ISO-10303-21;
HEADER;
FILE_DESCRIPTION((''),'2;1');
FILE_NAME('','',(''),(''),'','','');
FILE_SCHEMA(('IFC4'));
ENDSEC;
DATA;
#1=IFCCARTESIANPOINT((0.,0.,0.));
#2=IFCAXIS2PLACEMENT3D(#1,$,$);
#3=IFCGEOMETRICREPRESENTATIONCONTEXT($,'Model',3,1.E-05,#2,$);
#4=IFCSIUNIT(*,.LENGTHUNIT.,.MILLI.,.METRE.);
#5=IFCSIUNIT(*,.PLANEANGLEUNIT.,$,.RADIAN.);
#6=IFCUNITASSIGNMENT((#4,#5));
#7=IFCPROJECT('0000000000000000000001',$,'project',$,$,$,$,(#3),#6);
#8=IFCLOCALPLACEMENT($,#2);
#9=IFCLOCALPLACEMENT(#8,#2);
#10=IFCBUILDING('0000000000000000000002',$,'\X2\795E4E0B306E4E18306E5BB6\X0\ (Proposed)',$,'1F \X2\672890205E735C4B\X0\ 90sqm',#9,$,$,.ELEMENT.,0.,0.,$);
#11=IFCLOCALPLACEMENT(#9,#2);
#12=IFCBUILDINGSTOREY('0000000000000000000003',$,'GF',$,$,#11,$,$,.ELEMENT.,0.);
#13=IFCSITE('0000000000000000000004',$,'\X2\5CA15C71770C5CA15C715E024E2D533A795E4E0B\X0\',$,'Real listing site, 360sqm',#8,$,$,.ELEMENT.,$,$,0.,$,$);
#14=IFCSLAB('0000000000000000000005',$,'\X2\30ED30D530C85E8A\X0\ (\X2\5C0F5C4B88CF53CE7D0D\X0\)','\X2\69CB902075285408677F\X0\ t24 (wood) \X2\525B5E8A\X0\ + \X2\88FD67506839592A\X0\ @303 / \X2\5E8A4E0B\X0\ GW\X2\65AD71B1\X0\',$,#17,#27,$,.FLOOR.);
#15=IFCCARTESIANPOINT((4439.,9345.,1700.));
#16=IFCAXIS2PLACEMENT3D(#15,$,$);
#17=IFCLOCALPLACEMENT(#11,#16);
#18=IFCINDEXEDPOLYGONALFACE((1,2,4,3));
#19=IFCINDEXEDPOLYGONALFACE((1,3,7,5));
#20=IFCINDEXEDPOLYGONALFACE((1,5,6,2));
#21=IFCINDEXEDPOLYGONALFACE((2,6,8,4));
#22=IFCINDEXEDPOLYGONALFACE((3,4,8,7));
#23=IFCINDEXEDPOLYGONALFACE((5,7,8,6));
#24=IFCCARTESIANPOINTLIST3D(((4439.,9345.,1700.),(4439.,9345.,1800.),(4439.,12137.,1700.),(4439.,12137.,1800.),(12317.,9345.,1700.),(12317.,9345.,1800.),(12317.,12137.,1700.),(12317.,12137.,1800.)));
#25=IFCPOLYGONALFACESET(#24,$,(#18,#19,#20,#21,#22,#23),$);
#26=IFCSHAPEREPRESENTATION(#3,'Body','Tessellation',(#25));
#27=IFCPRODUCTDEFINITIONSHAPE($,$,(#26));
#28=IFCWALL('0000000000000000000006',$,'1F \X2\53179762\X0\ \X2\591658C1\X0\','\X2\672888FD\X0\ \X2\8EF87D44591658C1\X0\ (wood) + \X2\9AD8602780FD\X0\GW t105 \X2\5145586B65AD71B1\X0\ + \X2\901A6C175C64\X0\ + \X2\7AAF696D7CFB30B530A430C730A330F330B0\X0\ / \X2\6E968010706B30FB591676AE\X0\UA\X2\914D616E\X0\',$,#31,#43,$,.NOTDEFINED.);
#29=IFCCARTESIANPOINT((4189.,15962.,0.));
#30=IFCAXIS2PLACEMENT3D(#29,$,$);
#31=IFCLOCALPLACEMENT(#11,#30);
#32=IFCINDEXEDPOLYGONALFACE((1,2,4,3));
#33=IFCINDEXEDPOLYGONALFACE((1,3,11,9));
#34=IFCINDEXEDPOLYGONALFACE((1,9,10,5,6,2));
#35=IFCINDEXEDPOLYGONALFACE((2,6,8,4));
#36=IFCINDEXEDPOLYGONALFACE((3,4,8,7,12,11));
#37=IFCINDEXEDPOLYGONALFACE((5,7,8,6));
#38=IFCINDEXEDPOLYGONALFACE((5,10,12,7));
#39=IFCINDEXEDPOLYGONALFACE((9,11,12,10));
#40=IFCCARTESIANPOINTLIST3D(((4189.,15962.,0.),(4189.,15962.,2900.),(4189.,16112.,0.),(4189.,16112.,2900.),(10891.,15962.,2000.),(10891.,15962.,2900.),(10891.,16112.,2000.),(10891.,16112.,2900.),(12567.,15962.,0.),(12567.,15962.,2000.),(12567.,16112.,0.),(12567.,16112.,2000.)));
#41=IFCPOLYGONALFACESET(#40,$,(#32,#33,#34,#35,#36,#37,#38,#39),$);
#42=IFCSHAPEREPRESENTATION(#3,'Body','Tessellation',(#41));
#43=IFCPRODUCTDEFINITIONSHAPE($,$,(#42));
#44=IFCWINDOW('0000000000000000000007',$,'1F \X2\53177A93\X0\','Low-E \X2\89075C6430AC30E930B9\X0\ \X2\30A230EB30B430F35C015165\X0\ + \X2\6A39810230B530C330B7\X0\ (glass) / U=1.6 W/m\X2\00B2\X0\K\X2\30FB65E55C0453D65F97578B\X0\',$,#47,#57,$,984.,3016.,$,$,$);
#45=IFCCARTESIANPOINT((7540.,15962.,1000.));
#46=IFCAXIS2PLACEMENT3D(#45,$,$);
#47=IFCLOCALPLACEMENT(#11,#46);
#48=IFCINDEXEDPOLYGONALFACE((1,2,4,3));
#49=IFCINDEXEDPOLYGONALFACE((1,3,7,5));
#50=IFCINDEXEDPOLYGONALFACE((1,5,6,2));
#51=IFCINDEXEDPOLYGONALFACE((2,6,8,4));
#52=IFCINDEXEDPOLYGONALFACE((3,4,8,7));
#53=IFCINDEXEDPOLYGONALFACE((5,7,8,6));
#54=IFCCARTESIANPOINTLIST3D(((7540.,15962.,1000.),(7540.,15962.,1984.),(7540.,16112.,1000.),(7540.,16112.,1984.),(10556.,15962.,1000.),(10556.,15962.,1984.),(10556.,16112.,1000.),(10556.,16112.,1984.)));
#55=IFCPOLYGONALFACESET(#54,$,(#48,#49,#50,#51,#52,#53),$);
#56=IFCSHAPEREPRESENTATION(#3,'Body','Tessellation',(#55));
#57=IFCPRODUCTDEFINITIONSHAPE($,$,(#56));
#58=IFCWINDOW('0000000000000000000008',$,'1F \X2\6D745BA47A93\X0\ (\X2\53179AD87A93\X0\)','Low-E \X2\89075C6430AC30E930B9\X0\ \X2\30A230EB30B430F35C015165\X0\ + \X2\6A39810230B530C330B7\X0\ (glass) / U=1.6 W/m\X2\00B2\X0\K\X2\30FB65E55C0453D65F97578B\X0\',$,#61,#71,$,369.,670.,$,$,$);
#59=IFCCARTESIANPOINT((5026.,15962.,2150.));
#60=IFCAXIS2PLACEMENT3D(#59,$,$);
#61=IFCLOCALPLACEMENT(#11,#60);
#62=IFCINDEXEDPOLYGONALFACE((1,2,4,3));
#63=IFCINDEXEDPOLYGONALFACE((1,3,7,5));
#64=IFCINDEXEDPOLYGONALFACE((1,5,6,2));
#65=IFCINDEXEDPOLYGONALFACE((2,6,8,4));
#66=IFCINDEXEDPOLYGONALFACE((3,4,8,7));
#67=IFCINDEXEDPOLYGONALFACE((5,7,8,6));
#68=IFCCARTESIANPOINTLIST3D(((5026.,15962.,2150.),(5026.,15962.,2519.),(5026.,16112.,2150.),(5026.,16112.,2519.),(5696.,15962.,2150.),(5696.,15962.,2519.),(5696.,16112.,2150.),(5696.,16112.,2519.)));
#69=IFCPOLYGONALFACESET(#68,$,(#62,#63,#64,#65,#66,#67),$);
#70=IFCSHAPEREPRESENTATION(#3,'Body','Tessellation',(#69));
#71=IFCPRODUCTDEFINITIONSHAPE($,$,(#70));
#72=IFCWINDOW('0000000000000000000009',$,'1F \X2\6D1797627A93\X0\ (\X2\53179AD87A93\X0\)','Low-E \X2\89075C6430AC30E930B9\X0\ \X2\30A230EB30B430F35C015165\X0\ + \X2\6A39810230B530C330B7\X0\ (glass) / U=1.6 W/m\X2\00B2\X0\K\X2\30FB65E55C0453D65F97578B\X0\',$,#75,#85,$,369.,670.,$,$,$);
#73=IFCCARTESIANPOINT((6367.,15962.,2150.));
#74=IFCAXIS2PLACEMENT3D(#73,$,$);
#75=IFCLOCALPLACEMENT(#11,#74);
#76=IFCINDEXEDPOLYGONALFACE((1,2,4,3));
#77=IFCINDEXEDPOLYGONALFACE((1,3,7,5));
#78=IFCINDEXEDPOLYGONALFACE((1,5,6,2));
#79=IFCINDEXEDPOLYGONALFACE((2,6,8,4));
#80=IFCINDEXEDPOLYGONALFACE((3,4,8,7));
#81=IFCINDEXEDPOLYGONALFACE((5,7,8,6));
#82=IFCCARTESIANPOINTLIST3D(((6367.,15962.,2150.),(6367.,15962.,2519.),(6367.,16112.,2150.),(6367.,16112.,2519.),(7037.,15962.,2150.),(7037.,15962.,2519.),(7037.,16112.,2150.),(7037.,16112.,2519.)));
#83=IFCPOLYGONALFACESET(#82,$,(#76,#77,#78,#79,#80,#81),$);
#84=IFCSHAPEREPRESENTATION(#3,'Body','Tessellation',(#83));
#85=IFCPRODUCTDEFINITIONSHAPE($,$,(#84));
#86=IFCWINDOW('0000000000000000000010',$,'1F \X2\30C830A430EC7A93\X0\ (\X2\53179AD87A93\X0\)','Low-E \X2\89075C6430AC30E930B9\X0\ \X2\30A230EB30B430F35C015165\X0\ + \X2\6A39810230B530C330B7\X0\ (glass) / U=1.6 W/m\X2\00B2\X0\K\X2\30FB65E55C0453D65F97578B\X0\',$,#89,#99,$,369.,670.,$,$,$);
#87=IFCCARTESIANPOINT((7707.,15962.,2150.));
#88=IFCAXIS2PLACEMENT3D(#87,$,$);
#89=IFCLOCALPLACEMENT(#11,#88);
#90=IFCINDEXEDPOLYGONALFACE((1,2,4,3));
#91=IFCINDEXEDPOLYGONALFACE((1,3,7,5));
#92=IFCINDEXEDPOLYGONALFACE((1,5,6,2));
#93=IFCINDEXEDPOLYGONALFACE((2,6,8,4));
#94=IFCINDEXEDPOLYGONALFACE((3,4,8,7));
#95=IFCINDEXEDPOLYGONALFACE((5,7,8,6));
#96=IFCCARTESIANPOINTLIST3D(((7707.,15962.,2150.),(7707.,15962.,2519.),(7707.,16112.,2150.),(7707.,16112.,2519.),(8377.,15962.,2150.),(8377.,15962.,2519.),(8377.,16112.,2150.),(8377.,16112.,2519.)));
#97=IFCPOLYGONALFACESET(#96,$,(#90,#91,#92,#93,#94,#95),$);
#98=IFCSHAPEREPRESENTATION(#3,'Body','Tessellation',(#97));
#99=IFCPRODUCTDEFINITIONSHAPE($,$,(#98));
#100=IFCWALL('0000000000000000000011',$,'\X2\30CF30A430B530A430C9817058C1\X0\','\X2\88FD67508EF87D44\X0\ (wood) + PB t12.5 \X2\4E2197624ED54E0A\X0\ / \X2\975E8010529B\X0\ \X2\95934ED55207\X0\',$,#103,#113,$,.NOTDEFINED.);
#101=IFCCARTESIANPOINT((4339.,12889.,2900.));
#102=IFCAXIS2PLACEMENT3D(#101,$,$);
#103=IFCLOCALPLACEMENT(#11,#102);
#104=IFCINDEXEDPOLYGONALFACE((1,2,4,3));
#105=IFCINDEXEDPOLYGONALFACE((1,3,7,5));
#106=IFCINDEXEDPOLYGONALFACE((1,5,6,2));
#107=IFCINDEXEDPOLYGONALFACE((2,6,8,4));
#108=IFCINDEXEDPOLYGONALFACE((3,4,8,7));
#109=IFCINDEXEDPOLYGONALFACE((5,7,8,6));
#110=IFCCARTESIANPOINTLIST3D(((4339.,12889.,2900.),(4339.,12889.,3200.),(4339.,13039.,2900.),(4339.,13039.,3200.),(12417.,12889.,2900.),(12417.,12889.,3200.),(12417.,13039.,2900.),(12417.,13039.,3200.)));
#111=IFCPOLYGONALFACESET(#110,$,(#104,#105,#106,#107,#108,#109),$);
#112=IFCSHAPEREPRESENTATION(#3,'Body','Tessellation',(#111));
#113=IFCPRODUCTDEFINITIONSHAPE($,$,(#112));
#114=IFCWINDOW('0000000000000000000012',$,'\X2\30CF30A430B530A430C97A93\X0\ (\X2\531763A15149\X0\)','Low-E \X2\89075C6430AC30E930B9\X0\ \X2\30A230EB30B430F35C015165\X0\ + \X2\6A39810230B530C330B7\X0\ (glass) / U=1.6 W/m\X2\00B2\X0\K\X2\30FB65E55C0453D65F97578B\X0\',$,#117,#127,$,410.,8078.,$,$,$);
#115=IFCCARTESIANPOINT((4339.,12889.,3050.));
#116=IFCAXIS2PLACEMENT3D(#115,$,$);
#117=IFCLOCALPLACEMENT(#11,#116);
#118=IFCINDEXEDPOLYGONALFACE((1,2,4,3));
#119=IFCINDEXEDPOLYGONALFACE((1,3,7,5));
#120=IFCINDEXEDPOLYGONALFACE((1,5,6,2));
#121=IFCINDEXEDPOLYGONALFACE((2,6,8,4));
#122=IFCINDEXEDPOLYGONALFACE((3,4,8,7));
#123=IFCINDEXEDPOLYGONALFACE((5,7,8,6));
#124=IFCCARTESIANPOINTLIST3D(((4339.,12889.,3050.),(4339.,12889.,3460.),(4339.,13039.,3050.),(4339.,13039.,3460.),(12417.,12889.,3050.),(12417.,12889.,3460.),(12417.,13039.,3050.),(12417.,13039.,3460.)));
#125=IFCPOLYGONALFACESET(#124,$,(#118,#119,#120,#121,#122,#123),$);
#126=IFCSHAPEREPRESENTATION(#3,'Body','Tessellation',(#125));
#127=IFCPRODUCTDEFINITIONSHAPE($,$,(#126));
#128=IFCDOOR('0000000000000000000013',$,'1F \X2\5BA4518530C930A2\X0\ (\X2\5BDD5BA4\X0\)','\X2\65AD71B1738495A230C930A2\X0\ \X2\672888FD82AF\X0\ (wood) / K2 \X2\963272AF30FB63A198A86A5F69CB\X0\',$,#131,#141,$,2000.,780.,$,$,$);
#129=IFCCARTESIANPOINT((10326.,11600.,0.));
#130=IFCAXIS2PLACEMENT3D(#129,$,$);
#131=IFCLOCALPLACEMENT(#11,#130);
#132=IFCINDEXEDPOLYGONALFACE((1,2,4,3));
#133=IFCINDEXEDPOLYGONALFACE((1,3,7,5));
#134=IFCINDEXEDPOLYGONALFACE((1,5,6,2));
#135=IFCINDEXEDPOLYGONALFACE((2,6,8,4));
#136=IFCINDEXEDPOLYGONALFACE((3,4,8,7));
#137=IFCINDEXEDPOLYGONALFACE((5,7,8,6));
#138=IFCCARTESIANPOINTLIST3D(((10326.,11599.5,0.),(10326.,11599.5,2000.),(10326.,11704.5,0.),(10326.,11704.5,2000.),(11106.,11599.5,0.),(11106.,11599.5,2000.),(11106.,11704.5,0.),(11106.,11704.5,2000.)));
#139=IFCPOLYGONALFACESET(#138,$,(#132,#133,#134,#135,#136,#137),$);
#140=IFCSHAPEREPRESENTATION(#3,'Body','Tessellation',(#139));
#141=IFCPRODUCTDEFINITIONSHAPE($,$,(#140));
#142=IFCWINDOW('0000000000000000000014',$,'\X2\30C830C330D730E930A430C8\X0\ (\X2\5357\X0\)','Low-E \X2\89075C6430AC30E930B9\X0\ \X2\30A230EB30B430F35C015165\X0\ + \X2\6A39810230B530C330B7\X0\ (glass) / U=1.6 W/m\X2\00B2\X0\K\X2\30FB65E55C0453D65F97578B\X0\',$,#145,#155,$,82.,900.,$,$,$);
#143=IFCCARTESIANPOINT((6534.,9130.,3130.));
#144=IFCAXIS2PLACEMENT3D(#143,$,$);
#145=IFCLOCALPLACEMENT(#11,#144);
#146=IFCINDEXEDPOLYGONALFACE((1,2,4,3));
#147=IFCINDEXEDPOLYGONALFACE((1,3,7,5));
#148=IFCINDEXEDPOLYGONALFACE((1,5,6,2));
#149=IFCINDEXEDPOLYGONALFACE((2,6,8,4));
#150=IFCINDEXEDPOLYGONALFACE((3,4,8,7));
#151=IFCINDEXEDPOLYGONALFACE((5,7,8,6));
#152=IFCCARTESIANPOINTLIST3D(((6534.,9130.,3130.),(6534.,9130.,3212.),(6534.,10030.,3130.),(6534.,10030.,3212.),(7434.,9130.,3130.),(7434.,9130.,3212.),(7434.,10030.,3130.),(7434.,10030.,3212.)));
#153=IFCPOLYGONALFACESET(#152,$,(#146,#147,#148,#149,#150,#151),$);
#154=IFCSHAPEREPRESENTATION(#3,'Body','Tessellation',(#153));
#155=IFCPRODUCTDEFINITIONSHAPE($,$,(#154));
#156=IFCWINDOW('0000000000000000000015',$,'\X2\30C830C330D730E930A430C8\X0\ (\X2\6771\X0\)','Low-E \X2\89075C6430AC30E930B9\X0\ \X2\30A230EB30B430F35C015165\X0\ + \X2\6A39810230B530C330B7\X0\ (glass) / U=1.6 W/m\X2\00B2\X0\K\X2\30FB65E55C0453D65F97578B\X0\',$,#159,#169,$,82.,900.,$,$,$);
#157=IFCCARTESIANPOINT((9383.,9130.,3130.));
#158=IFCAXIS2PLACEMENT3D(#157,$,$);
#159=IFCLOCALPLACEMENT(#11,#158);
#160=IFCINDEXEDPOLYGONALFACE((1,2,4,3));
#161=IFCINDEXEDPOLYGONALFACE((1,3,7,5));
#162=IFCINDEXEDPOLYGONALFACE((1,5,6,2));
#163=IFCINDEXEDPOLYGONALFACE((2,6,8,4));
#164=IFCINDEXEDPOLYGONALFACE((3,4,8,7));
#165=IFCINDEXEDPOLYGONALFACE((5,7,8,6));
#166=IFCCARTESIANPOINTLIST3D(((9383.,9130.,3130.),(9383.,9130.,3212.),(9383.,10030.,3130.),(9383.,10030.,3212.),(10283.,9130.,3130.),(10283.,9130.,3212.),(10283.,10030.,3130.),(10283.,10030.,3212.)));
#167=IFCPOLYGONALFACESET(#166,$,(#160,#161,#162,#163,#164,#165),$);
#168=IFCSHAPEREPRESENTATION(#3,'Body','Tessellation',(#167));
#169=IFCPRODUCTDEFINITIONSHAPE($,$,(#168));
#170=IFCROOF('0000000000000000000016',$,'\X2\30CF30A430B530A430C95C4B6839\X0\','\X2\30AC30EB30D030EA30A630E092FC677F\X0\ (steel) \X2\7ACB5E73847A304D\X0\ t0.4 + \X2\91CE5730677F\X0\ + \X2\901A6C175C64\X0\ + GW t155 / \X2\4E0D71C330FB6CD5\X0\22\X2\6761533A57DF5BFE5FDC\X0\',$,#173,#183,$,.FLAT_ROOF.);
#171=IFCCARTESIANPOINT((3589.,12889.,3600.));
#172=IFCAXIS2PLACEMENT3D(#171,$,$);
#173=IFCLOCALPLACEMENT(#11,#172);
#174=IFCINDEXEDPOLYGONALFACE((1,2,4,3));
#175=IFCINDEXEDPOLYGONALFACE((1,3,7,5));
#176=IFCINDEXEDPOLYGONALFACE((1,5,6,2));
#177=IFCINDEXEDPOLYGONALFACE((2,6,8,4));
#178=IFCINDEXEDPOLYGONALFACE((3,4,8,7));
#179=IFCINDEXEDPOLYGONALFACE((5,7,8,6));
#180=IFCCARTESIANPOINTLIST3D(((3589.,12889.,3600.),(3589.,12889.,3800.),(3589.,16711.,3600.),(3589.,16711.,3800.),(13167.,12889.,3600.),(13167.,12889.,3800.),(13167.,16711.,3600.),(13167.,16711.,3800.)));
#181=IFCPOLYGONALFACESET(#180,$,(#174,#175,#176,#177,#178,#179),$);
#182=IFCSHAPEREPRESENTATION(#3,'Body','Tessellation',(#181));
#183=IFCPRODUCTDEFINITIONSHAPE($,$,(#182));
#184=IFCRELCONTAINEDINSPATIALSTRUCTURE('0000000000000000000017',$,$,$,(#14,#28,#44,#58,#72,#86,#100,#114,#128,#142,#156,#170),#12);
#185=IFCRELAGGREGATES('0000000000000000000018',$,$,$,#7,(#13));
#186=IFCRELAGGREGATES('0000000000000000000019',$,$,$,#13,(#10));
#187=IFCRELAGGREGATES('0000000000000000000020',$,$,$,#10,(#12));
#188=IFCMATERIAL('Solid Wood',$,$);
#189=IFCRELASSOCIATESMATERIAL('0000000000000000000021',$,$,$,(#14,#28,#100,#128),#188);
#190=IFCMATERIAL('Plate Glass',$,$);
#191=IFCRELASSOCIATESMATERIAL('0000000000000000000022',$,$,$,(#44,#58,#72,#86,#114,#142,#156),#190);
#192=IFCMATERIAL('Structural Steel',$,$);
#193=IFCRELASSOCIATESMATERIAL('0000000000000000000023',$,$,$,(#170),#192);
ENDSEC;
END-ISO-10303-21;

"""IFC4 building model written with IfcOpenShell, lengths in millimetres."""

from ifc_helpers import new_model, si_unit, frame, frame_2d, origin, place, context, project, spatial, rectangle, extrude, material, element, fill, save


model = new_model("IFC4")

# Units and contexts
model_context = context("Model", 3, precision=1e-05, world=origin())
ifc_project = project(units=[si_unit("LENGTHUNIT", "METRE", prefix="MILLI"), si_unit("PLANEANGLEUNIT", "RADIAN")], contexts=[model_context])

# Site, building, storey
site_placement = place(None, origin())
site = spatial("IfcSite", under=ifc_project, at=site_placement, Name="岡山県岡山市中区神下", ObjectType="Real listing site, 360sqm", CompositionType="ELEMENT", RefElevation=0.0)
building_placement = place(site_placement, origin())
building = spatial("IfcBuilding", under=site, at=building_placement, Name="神下の丘の家 (Proposed)", ObjectType="1F 木造平屋 90sqm", CompositionType="ELEMENT", ElevationOfRefHeight=0.0, ElevationOfTerrain=0.0)
storey_placement = place(building_placement, origin())
storey = spatial("IfcBuildingStorey", under=building, at=storey_placement, Name="GF", CompositionType="ELEMENT", Elevation=0.0)

# Slab
ifc_material_1 = material(Name="Solid Wood")
slab_placement = place(storey_placement, frame((4439.0, 9345.0, 1700.0)))
element("IfcSlab", 1, at=slab_placement, inside=storey, material=ifc_material_1, Name="ロフト床 (小屋裏収納)", Description="構造用合板 t24 (wood) 剛床 + 製材根太 @303 / 床下 GW断熱", PredefinedType="FLOOR", context=model_context, shape_type="SweptSolid", body=[
    extrude(rectangle(XDim=7878.0, YDim=2792.0, at=frame_2d((3939.0, 1396.0))), frame((4439.0, 9345.0, 1700.0)), (0.0, 0.0, 1.0), 100.0),
])

# Wall, openings, windows
wall_1_placement = place(storey_placement, frame((4189.0, 15962.0, 0.0)))
wall_1 = element("IfcWall", 2, at=wall_1_placement, inside=storey, material=ifc_material_1, Name="1F 北面 外壁", Description="木製 軸組外壁 (wood) + 高性能GW t105 充填断熱 + 通気層 + 窯業系サイディング / 準耐火・外皮UA配慮", PredefinedType="NOTDEFINED", context=model_context, shape_type="SweptSolid", body=[
    extrude(rectangle(XDim=8378.0, YDim=150.0, at=frame_2d((4189.0, 75.0))), frame((4189.0, 15962.0, 0.0)), (0.0, 0.0, 1.0), 2900.0),
])
opening_1_placement = place(storey_placement, frame((7540.0, 15962.0, 1000.0)))
opening_1 = element("IfcOpeningElement", 3, at=opening_1_placement, cuts=wall_1, PredefinedType="NOTDEFINED", context=model_context, shape_type="SweptSolid", body=[
    extrude(rectangle(XDim=3016.0, YDim=150.0, at=frame_2d((1508.0, 75.0))), frame((7540.0, 15962.0, 1000.0)), (0.0, 0.0, 1.0), 984.0),
])
opening_2_placement = place(storey_placement, frame((5026.0, 15962.0, 2150.0)))
opening_2 = element("IfcOpeningElement", 4, at=opening_2_placement, cuts=wall_1, PredefinedType="NOTDEFINED", context=model_context, shape_type="SweptSolid", body=[
    extrude(rectangle(XDim=670.0, YDim=150.0, at=frame_2d((335.0, 75.0))), frame((5026.0, 15962.0, 2150.0)), (0.0, 0.0, 1.0), 369.0),
])
opening_3_placement = place(storey_placement, frame((6367.0, 15962.0, 2150.0)))
opening_3 = element("IfcOpeningElement", 5, at=opening_3_placement, cuts=wall_1, PredefinedType="NOTDEFINED", context=model_context, shape_type="SweptSolid", body=[
    extrude(rectangle(XDim=670.0, YDim=150.0, at=frame_2d((335.0, 75.0))), frame((6367.0, 15962.0, 2150.0)), (0.0, 0.0, 1.0), 369.0),
])
opening_4_placement = place(storey_placement, frame((7707.0, 15962.0, 2150.0)))
opening_4 = element("IfcOpeningElement", 6, at=opening_4_placement, cuts=wall_1, PredefinedType="NOTDEFINED", context=model_context, shape_type="SweptSolid", body=[
    extrude(rectangle(XDim=670.0, YDim=150.0, at=frame_2d((335.0, 75.0))), frame((7707.0, 15962.0, 2150.0)), (0.0, 0.0, 1.0), 369.0),
])
ifc_material_2 = material(Name="Plate Glass")
window_1_placement = place(storey_placement, frame((7540.0, 15962.0, 1000.0)))
window_1 = element("IfcWindow", 7, at=window_1_placement, inside=storey, material=ifc_material_2, Name="1F 北窓", Description="Low-E 複層ガラス アルゴン封入 + 樹脂サッシ (glass) / U=1.6 W/m²K・日射取得型", OverallHeight=984.0, OverallWidth=3016.0, context=model_context, shape_type="SweptSolid", body=[
    extrude(rectangle(XDim=3016.0, YDim=150.0, at=frame_2d((1508.0, 75.0))), frame((7540.0, 15962.0, 1000.0)), (0.0, 0.0, 1.0), 984.0),
])
fill(opening_1, window_1)
window_2_placement = place(storey_placement, frame((5026.0, 15962.0, 2150.0)))
window_2 = element("IfcWindow", 8, at=window_2_placement, inside=storey, material=ifc_material_2, Name="1F 浴室窓 (北高窓)", Description="Low-E 複層ガラス アルゴン封入 + 樹脂サッシ (glass) / U=1.6 W/m²K・日射取得型", OverallHeight=369.0, OverallWidth=670.0, context=model_context, shape_type="SweptSolid", body=[
    extrude(rectangle(XDim=670.0, YDim=150.0, at=frame_2d((335.0, 75.0))), frame((5026.0, 15962.0, 2150.0)), (0.0, 0.0, 1.0), 369.0),
])
fill(opening_2, window_2)
window_3_placement = place(storey_placement, frame((6367.0, 15962.0, 2150.0)))
window_3 = element("IfcWindow", 9, at=window_3_placement, inside=storey, material=ifc_material_2, Name="1F 洗面窓 (北高窓)", Description="Low-E 複層ガラス アルゴン封入 + 樹脂サッシ (glass) / U=1.6 W/m²K・日射取得型", OverallHeight=369.0, OverallWidth=670.0, context=model_context, shape_type="SweptSolid", body=[
    extrude(rectangle(XDim=670.0, YDim=150.0, at=frame_2d((335.0, 75.0))), frame((6367.0, 15962.0, 2150.0)), (0.0, 0.0, 1.0), 369.0),
])
fill(opening_3, window_3)
window_4_placement = place(storey_placement, frame((7707.0, 15962.0, 2150.0)))
window_4 = element("IfcWindow", 10, at=window_4_placement, inside=storey, material=ifc_material_2, Name="1F トイレ窓 (北高窓)", Description="Low-E 複層ガラス アルゴン封入 + 樹脂サッシ (glass) / U=1.6 W/m²K・日射取得型", OverallHeight=369.0, OverallWidth=670.0, context=model_context, shape_type="SweptSolid", body=[
    extrude(rectangle(XDim=670.0, YDim=150.0, at=frame_2d((335.0, 75.0))), frame((7707.0, 15962.0, 2150.0)), (0.0, 0.0, 1.0), 369.0),
])
fill(opening_4, window_4)

# Wall, opening, window
wall_2_placement = place(storey_placement, frame((4339.0, 12889.0, 2900.0)))
wall_2 = element("IfcWall", 11, at=wall_2_placement, inside=storey, material=ifc_material_1, Name="ハイサイド腰壁", Description="製材軸組 (wood) + PB t12.5 両面仕上 / 非耐力 間仕切", PredefinedType="NOTDEFINED", context=model_context, shape_type="SweptSolid", body=[
    extrude(rectangle(XDim=8078.0, YDim=150.0, at=frame_2d((4039.0, 75.0))), frame((4339.0, 12889.0, 2900.0)), (0.0, 0.0, 1.0), 700.0),
])
opening_5_placement = place(storey_placement, frame((4339.0, 12889.0, 3050.0)))
opening_5 = element("IfcOpeningElement", 12, at=opening_5_placement, cuts=wall_2, PredefinedType="NOTDEFINED", context=model_context, shape_type="SweptSolid", body=[
    extrude(rectangle(XDim=8078.0, YDim=150.0, at=frame_2d((4039.0, 75.0))), frame((4339.0, 12889.0, 3050.0)), (0.0, 0.0, 1.0), 410.0),
])
window_5_placement = place(storey_placement, frame((4339.0, 12889.0, 3050.0)))
window_5 = element("IfcWindow", 13, at=window_5_placement, inside=storey, material=ifc_material_2, Name="ハイサイド窓 (北採光)", Description="Low-E 複層ガラス アルゴン封入 + 樹脂サッシ (glass) / U=1.6 W/m²K・日射取得型", OverallHeight=410.0, OverallWidth=8078.0, context=model_context, shape_type="SweptSolid", body=[
    extrude(rectangle(XDim=8078.0, YDim=150.0, at=frame_2d((4039.0, 75.0))), frame((4339.0, 12889.0, 3050.0)), (0.0, 0.0, 1.0), 410.0),
])
fill(opening_5, window_5)

# Door
door_1_placement = place(storey_placement, frame((10326.0, 11600.0, 0.0)))
element("IfcDoor", 14, at=door_1_placement, inside=storey, material=ifc_material_1, Name="1F 室内ドア (寝室)", Description="断熱玄関ドア 木製芯 (wood) / K2 防犯・採風機構", OverallHeight=2000.0, OverallWidth=780.0, context=model_context, shape_type="SweptSolid", body=[
    extrude(rectangle(XDim=780.0, YDim=105.0, at=frame_2d((390.0, 52.0))), frame((10326.0, 11600.0, 0.0)), (0.0, 0.0, 1.0), 2000.0),
])

# Windows
window_6_placement = place(storey_placement, frame((6534.0, 9130.0, 3130.0)))
element("IfcWindow", 15, at=window_6_placement, inside=storey, material=ifc_material_2, Name="トップライト (南)", Description="Low-E 複層ガラス アルゴン封入 + 樹脂サッシ (glass) / U=1.6 W/m²K・日射取得型", OverallHeight=82.0, OverallWidth=900.0, context=model_context, shape_type="SweptSolid", body=[
    extrude(rectangle(XDim=900.0, YDim=900.0, at=frame_2d((450.0, 450.0))), frame((6534.0, 9130.0, 3130.0)), (0.0, 0.0, 1.0), 82.0),
])
window_7_placement = place(storey_placement, frame((9383.0, 9130.0, 3130.0)))
element("IfcWindow", 16, at=window_7_placement, inside=storey, material=ifc_material_2, Name="トップライト (東)", Description="Low-E 複層ガラス アルゴン封入 + 樹脂サッシ (glass) / U=1.6 W/m²K・日射取得型", OverallHeight=82.0, OverallWidth=900.0, context=model_context, shape_type="SweptSolid", body=[
    extrude(rectangle(XDim=900.0, YDim=900.0, at=frame_2d((450.0, 450.0))), frame((9383.0, 9130.0, 3130.0)), (0.0, 0.0, 1.0), 82.0),
])

# Roof
ifc_material_3 = material(Name="Structural Steel")
roof_placement = place(storey_placement, frame((3589.0, 12889.0, 3600.0)))
element("IfcRoof", 17, at=roof_placement, inside=storey, material=ifc_material_3, Name="ハイサイド屋根", Description="ガルバリウム鋼板 (steel) 立平葺き t0.4 + 野地板 + 通気層 + GW t155 / 不燃・法22条区域対応", PredefinedType="FLAT_ROOF", context=model_context, shape_type="SweptSolid", body=[
    extrude(rectangle(XDim=9578.0, YDim=3822.0, at=frame_2d((4789.0, 1911.0))), frame((3589.0, 12889.0, 3600.0)), (0.0, 0.0, 1.0), 200.0),
])

save(model, "model.ifc")
